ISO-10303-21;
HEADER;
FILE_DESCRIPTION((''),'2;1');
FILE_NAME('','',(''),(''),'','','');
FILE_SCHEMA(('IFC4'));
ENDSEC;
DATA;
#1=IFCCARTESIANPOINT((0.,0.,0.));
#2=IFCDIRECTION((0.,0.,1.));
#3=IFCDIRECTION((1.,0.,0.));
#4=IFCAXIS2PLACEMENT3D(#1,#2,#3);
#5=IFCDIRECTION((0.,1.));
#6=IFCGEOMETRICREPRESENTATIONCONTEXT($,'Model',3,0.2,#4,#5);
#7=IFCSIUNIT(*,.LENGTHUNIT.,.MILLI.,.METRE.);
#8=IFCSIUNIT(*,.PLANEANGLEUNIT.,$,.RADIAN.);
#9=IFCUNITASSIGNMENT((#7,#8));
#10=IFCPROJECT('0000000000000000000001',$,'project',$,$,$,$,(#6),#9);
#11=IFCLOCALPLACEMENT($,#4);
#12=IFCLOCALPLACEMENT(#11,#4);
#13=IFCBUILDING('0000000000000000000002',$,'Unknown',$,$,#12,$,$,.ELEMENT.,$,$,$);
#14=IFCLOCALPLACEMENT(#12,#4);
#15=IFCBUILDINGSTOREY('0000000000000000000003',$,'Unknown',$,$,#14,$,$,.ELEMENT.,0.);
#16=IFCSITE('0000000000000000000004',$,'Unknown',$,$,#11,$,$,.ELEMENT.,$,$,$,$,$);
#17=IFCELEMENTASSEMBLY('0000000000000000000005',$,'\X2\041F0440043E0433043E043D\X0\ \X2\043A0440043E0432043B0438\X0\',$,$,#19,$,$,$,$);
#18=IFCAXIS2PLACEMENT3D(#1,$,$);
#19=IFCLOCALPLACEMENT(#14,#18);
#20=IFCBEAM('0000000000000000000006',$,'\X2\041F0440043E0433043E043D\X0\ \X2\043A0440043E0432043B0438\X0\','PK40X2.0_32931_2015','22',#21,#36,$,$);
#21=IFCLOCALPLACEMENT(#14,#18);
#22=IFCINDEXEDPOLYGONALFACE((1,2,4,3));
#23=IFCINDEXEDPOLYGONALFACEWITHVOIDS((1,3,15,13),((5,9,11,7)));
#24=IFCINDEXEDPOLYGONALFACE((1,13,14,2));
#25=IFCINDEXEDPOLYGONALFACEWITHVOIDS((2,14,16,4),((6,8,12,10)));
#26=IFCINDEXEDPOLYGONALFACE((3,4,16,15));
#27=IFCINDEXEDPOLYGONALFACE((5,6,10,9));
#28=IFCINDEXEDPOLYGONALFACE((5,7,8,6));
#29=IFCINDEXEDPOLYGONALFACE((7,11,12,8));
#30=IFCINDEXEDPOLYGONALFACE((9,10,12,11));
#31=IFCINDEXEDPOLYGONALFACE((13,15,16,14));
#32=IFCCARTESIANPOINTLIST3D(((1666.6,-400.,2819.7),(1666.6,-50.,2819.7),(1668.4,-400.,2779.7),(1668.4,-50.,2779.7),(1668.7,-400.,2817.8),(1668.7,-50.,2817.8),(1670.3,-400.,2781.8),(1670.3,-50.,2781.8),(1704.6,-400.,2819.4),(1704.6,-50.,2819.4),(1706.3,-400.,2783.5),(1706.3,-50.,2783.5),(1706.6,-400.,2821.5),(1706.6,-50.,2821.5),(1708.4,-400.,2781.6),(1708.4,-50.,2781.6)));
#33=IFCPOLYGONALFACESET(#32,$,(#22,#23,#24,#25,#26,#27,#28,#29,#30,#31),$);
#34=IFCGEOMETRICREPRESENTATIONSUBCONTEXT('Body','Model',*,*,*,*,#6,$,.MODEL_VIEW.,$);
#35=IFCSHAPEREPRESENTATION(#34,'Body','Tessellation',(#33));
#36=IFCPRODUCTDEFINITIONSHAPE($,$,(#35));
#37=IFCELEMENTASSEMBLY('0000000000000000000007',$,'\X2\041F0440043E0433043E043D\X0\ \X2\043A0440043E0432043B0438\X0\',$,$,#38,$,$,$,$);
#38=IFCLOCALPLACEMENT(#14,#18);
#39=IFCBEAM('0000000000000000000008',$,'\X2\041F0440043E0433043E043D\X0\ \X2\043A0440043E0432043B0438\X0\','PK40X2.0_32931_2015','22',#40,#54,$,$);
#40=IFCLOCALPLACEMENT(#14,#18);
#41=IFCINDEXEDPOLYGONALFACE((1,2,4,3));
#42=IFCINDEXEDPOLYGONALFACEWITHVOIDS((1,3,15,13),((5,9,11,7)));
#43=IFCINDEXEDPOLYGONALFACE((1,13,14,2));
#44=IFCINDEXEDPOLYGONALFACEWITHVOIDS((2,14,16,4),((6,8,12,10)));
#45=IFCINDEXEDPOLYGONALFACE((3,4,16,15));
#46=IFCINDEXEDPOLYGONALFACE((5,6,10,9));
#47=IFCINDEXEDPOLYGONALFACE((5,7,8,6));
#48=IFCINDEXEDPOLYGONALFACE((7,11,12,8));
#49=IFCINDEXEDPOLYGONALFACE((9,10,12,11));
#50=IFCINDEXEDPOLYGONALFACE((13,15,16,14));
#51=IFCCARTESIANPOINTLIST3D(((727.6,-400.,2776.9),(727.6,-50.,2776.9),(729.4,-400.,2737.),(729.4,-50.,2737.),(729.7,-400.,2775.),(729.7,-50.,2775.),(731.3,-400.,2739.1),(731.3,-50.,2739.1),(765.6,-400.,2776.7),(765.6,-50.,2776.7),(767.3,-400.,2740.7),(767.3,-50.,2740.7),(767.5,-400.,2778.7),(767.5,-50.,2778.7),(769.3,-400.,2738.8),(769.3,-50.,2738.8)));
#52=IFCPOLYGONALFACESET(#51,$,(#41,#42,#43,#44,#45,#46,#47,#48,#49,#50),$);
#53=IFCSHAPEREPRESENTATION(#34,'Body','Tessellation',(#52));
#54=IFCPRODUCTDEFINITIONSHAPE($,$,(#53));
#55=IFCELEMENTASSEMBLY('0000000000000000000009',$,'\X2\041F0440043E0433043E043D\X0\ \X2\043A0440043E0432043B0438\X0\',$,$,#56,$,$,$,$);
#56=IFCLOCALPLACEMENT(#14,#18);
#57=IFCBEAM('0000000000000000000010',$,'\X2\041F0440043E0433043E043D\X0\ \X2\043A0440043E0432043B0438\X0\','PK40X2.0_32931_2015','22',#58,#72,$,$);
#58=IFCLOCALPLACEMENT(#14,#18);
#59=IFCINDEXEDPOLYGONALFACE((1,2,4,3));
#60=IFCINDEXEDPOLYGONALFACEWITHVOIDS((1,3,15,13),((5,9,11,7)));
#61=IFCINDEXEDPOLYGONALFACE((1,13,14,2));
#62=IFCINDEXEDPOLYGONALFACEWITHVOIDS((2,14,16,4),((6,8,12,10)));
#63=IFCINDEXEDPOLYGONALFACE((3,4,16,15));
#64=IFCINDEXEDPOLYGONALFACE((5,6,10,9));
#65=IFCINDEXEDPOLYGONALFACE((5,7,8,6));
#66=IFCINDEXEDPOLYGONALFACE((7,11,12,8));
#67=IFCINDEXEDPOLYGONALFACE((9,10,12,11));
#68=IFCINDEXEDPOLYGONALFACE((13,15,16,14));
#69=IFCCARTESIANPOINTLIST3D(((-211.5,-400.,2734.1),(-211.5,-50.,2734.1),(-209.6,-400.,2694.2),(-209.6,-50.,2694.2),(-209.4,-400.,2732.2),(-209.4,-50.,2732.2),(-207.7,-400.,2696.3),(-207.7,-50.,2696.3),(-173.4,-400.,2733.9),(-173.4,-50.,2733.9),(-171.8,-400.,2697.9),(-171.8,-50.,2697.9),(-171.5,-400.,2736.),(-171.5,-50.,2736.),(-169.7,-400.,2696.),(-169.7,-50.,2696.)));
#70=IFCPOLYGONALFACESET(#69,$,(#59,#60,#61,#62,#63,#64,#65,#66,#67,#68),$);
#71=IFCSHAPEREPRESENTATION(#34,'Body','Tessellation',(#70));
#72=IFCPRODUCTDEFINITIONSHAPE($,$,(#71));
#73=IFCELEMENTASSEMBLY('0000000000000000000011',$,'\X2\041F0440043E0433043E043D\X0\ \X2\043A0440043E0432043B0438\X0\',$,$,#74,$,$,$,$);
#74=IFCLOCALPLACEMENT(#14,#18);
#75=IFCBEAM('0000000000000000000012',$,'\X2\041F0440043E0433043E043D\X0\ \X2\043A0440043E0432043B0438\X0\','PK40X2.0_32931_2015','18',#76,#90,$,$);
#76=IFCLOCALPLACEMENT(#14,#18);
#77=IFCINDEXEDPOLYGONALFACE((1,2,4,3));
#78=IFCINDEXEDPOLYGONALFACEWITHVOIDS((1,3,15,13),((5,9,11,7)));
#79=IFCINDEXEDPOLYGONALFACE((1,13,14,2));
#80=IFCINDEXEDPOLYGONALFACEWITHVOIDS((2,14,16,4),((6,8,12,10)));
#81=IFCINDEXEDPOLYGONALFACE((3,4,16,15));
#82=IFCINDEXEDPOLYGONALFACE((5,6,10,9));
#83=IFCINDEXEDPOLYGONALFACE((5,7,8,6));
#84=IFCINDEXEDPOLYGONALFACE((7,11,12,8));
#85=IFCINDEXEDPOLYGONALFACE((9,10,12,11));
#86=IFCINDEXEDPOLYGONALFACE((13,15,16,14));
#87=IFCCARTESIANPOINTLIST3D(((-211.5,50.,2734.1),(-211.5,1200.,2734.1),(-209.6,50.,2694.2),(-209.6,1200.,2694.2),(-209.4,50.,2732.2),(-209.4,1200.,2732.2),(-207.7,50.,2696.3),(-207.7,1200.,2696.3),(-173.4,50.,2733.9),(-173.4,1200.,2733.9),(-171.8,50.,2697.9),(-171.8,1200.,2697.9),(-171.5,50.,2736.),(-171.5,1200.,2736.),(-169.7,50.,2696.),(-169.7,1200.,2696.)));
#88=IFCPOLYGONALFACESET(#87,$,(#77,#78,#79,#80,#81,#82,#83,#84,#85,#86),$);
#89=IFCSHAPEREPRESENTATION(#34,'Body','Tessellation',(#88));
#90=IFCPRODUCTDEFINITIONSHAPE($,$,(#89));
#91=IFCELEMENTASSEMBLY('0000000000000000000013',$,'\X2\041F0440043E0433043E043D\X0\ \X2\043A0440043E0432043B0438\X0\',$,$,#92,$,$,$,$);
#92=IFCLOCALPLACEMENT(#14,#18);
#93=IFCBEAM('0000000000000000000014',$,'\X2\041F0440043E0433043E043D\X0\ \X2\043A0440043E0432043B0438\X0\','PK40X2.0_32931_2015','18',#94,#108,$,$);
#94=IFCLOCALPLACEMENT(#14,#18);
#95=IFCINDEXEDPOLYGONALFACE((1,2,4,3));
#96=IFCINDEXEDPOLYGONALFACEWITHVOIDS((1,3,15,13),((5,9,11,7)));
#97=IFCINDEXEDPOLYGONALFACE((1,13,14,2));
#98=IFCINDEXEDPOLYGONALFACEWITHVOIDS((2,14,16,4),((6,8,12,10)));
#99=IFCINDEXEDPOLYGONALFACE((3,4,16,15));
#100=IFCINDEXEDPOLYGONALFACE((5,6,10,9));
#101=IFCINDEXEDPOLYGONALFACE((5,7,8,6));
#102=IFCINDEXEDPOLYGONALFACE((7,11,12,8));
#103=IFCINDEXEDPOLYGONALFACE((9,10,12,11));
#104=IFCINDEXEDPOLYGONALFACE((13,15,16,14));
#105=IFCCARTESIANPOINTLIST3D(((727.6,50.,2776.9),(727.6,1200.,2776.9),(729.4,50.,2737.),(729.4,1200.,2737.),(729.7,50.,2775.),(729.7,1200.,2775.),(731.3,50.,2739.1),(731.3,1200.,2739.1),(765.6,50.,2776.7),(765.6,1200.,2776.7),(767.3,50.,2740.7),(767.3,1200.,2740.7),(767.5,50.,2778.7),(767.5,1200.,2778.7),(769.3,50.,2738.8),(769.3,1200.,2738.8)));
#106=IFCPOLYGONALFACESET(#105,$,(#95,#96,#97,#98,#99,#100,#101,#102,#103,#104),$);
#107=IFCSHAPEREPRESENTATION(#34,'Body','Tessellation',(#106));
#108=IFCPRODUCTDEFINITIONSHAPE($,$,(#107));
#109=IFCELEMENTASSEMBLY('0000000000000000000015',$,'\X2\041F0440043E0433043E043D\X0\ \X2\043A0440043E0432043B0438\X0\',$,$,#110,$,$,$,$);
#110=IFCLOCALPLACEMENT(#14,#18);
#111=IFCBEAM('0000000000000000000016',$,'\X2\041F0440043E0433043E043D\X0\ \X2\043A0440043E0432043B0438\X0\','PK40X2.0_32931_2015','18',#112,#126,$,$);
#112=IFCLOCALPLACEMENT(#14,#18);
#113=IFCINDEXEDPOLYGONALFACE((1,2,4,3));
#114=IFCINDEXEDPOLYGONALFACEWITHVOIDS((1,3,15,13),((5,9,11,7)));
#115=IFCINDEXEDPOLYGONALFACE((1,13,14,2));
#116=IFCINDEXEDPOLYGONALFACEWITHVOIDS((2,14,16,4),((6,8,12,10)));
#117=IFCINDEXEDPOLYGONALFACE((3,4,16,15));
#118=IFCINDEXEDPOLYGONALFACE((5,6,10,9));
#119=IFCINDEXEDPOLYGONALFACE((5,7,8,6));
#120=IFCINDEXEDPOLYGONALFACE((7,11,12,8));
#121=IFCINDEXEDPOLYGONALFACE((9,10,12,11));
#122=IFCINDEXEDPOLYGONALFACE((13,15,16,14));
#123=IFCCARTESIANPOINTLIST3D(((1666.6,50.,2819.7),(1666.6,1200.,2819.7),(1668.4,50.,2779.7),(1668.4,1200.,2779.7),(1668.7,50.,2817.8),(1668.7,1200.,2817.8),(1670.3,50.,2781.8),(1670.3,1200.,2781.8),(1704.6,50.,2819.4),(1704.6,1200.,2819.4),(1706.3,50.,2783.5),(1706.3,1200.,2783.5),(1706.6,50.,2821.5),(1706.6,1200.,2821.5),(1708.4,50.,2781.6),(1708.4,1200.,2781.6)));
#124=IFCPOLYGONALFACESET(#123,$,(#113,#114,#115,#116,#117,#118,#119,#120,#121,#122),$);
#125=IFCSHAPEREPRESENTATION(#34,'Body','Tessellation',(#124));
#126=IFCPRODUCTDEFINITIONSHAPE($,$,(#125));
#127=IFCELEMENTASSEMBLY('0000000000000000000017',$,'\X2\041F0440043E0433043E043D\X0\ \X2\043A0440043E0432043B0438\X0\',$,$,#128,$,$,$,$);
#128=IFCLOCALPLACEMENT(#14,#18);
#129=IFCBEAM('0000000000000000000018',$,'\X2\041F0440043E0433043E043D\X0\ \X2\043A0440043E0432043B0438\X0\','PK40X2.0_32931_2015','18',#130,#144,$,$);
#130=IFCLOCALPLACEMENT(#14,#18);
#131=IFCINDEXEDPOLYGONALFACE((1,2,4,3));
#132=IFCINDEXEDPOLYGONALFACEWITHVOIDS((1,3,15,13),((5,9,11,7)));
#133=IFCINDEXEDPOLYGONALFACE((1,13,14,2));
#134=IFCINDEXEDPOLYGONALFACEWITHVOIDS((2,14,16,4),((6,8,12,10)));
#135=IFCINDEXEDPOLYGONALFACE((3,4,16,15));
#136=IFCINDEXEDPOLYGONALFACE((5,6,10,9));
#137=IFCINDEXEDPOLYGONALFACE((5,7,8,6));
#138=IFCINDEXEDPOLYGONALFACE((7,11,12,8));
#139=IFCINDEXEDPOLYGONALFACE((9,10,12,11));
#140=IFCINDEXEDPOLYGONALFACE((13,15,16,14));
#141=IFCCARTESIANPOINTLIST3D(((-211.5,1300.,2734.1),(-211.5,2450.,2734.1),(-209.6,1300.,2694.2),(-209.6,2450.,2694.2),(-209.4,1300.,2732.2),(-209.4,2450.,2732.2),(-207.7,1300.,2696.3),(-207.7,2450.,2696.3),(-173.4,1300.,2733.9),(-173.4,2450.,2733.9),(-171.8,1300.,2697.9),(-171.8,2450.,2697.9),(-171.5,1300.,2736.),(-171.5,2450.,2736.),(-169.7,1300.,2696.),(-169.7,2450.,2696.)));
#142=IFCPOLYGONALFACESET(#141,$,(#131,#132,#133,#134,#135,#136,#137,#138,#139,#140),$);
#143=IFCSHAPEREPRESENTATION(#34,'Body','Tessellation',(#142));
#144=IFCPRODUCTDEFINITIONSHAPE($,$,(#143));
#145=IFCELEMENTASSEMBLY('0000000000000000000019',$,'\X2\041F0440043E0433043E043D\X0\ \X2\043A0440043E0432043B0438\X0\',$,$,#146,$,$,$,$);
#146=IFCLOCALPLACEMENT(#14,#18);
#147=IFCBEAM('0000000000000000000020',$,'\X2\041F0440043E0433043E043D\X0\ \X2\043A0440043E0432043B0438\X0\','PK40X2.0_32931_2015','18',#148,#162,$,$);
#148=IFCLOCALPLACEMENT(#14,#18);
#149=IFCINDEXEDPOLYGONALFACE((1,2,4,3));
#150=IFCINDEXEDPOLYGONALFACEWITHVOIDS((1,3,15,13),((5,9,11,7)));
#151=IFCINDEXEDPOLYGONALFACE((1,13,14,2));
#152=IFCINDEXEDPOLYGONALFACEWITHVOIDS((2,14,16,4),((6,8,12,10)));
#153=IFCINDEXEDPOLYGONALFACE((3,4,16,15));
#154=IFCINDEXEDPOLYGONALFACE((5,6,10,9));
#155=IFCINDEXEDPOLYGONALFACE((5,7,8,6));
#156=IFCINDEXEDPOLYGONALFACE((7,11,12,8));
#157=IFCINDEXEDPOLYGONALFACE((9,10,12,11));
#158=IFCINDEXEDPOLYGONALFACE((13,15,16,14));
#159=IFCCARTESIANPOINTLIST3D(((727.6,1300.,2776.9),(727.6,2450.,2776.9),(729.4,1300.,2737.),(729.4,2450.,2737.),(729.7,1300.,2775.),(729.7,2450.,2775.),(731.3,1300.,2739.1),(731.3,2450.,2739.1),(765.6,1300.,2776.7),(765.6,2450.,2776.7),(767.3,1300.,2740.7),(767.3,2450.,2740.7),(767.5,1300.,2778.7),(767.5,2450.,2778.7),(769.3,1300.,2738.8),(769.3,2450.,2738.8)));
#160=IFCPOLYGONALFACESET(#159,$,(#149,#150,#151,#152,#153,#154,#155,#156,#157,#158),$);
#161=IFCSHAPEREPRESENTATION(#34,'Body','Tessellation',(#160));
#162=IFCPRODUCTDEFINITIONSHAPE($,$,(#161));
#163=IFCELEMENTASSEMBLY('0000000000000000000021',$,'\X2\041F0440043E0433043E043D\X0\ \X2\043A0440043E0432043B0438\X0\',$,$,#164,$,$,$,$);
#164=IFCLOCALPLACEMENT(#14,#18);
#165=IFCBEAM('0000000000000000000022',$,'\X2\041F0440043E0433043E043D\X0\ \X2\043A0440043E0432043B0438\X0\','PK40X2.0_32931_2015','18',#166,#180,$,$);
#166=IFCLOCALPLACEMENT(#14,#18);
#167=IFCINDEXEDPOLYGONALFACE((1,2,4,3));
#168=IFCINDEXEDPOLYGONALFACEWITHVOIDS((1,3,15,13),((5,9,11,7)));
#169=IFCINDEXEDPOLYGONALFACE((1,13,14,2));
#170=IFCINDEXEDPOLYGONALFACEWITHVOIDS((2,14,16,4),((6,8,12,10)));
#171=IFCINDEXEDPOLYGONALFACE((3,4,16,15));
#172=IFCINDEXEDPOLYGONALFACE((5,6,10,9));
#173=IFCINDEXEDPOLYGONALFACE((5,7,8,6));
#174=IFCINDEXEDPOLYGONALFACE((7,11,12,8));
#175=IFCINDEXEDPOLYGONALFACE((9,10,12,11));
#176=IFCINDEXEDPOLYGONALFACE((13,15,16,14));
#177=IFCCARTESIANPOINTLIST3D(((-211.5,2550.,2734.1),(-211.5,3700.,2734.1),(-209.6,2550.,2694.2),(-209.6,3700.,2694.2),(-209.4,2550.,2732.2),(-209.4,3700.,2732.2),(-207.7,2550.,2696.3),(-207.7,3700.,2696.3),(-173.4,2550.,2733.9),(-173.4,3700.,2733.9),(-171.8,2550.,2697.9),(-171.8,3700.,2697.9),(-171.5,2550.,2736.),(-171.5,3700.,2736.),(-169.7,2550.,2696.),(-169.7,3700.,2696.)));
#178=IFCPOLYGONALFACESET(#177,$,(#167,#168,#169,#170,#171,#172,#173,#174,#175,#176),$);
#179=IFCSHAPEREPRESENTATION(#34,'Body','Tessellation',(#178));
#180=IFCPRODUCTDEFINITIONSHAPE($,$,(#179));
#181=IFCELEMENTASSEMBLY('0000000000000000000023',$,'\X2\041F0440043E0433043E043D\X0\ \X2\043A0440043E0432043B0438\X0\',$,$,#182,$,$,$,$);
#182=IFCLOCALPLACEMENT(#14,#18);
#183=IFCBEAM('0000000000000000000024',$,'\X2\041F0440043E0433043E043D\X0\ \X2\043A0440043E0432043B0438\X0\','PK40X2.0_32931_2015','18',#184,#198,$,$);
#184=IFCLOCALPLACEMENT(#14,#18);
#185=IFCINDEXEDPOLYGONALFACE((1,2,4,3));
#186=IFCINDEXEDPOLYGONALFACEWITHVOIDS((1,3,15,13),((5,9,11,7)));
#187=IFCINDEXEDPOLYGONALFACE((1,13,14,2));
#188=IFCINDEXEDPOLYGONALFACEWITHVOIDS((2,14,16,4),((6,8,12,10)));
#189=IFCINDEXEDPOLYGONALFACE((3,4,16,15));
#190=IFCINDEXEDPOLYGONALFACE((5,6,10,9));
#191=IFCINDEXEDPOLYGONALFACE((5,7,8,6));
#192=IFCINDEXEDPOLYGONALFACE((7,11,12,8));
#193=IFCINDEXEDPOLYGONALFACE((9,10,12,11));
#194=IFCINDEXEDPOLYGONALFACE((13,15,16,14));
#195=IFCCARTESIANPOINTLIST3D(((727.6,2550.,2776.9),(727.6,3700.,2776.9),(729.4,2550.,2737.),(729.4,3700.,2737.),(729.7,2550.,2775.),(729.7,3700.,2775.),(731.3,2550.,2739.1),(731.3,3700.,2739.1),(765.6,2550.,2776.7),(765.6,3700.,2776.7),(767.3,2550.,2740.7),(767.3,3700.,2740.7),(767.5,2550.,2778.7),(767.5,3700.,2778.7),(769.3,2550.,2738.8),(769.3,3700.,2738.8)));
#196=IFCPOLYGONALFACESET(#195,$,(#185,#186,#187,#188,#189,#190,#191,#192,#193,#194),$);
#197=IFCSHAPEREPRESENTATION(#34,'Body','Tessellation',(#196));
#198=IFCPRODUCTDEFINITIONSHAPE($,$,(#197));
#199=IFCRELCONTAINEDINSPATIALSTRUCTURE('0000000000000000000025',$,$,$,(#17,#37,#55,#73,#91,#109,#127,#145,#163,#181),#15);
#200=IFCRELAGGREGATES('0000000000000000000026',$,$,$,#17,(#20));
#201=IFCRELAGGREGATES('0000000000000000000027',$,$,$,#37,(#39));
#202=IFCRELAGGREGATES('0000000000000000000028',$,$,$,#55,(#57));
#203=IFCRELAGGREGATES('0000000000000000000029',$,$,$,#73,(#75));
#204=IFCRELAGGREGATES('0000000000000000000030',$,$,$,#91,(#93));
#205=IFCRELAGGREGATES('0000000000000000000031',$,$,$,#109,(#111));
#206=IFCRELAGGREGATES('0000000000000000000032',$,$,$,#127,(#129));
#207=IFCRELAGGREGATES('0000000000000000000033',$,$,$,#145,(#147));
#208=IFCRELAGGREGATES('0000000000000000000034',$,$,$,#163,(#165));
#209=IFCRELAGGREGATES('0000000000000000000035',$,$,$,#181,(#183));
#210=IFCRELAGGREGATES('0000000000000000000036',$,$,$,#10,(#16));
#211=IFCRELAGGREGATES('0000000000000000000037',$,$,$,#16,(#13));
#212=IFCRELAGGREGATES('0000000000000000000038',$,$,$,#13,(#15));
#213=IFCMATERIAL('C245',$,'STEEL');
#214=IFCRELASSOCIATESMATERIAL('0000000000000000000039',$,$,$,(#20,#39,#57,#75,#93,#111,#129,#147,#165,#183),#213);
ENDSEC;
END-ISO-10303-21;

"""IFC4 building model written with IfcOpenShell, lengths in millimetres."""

from ifc_helpers import new_model, si_unit, direction, frame, origin_with_axes, place, context, subcontext, project, spatial, line, indexed_curve, outline, extrude, material, element, aggregate, save


model = new_model("IFC4")

# Units and contexts
model_context = context("Model", 3, precision=0.2, world=origin_with_axes(), true_north=direction((0.0, 1.0)))
body_context = subcontext(model_context, "Body", "Model", "MODEL_VIEW")
ifc_project = project(units=[si_unit("LENGTHUNIT", "METRE", prefix="MILLI"), si_unit("PLANEANGLEUNIT", "RADIAN")], contexts=[model_context])

# Site, building, storey
site_placement = place(None, origin_with_axes())
site = spatial("IfcSite", under=ifc_project, at=site_placement, Name="Unknown", CompositionType="ELEMENT")
building_placement = place(site_placement, origin_with_axes())
building = spatial("IfcBuilding", under=site, at=building_placement, Name="Unknown", CompositionType="ELEMENT")
storey_placement = place(building_placement, origin_with_axes())
storey = spatial("IfcBuildingStorey", under=building, at=storey_placement, Name="Unknown", CompositionType="ELEMENT", Elevation=0.0)

# Shared definitions
ifc_material = material(Name="C245", Category="STEEL")

# Element assemblies, beams
assembly_1_placement = place(storey_placement, frame((1687.5, -50.0, 2800.6), z_axis=(-0.998964, 0.0, -0.045508), x_axis=(0.0, -1.0, 0.0)))
assembly_1 = element("IfcElementAssembly", 1, at=assembly_1_placement, inside=storey, Name="Прогон кровли")
beam_1_placement = place(assembly_1_placement, origin_with_axes())
beam_1 = element("IfcBeam", 2, at=beam_1_placement, material=ifc_material, Name="Прогон кровли", Description="PK40X2.0_32931_2015", ObjectType="22", context=body_context, shape_type="SolidModel", body=[
    extrude(outline(indexed_curve([(-20.0, -20.0), (20.0, -20.0), (20.0, 20.0), (-20.0, 20.0)], segments=[line(1, 2, 3, 4, 1)]), holes=[indexed_curve([(-18.0, -18.0), (-18.0, 18.0), (18.0, 18.0), (18.0, -18.0)], segments=[line(1, 2, 3, 4, 1)])]), frame((0.0, 0.0, 0.0), z_axis=(-1.0, 0.0, 0.0), x_axis=(0.0, 0.0, 1.0)), (0.0, 0.0, -1.0), 350.0),
])
aggregate(assembly_1, [beam_1])
assembly_2_placement = place(storey_placement, frame((748.5, -50.0, 2757.9), z_axis=(-0.998964, 0.0, -0.045508), x_axis=(0.0, -1.0, 0.0)))
assembly_2 = element("IfcElementAssembly", 3, at=assembly_2_placement, inside=storey, Name="Прогон кровли")
beam_2_placement = place(assembly_2_placement, origin_with_axes())
beam_2 = element("IfcBeam", 4, at=beam_2_placement, material=ifc_material, Name="Прогон кровли", Description="PK40X2.0_32931_2015", ObjectType="22", context=body_context, shape_type="SolidModel", body=[
    extrude(outline(indexed_curve([(-20.0, -20.0), (20.0, -20.0), (20.0, 20.0), (-20.0, 20.0)], segments=[line(1, 2, 3, 4, 1)]), holes=[indexed_curve([(-18.0, -18.0), (-18.0, 18.0), (18.0, 18.0), (18.0, -18.0)], segments=[line(1, 2, 3, 4, 1)])]), frame((0.0, 0.0, 0.0), z_axis=(-1.0, 0.0, 0.0), x_axis=(0.0, 0.0, 1.0)), (0.0, 0.0, -1.0), 350.0),
])
aggregate(assembly_2, [beam_2])
assembly_3_placement = place(storey_placement, frame((-190.6, -50.0, 2715.1), z_axis=(-0.998964, 0.0, -0.045508), x_axis=(0.0, -1.0, 0.0)))
assembly_3 = element("IfcElementAssembly", 5, at=assembly_3_placement, inside=storey, Name="Прогон кровли")
beam_3_placement = place(assembly_3_placement, origin_with_axes())
beam_3 = element("IfcBeam", 6, at=beam_3_placement, material=ifc_material, Name="Прогон кровли", Description="PK40X2.0_32931_2015", ObjectType="22", context=body_context, shape_type="SolidModel", body=[
    extrude(outline(indexed_curve([(-20.0, -20.0), (20.0, -20.0), (20.0, 20.0), (-20.0, 20.0)], segments=[line(1, 2, 3, 4, 1)]), holes=[indexed_curve([(-18.0, -18.0), (-18.0, 18.0), (18.0, 18.0), (18.0, -18.0)], segments=[line(1, 2, 3, 4, 1)])]), frame((0.0, 0.0, 0.0), z_axis=(-1.0, 0.0, 0.0), x_axis=(0.0, 0.0, 1.0)), (0.0, 0.0, -1.0), 350.0),
])
aggregate(assembly_3, [beam_3])
assembly_4_placement = place(storey_placement, frame((-190.6, 1200.0, 2715.1), z_axis=(-0.998964, 0.0, -0.045508), x_axis=(0.0, -1.0, 0.0)))
assembly_4 = element("IfcElementAssembly", 7, at=assembly_4_placement, inside=storey, Name="Прогон кровли")
beam_4_placement = place(assembly_4_placement, origin_with_axes())
beam_4 = element("IfcBeam", 8, at=beam_4_placement, material=ifc_material, Name="Прогон кровли", Description="PK40X2.0_32931_2015", ObjectType="18", context=body_context, shape_type="SolidModel", body=[
    extrude(outline(indexed_curve([(-20.0, -20.0), (20.0, -20.0), (20.0, 20.0), (-20.0, 20.0)], segments=[line(1, 2, 3, 4, 1)]), holes=[indexed_curve([(-18.0, -18.0), (-18.0, 18.0), (18.0, 18.0), (18.0, -18.0)], segments=[line(1, 2, 3, 4, 1)])]), frame((0.0, 0.0, 0.0), z_axis=(-1.0, 0.0, 0.0), x_axis=(0.0, 0.0, 1.0)), (0.0, 0.0, -1.0), 1150.0),
])
aggregate(assembly_4, [beam_4])
assembly_5_placement = place(storey_placement, frame((748.5, 1200.0, 2757.9), z_axis=(-0.998964, 0.0, -0.045508), x_axis=(0.0, -1.0, 0.0)))
assembly_5 = element("IfcElementAssembly", 9, at=assembly_5_placement, inside=storey, Name="Прогон кровли")
beam_5_placement = place(assembly_5_placement, origin_with_axes())
beam_5 = element("IfcBeam", 10, at=beam_5_placement, material=ifc_material, Name="Прогон кровли", Description="PK40X2.0_32931_2015", ObjectType="18", context=body_context, shape_type="SolidModel", body=[
    extrude(outline(indexed_curve([(-20.0, -20.0), (20.0, -20.0), (20.0, 20.0), (-20.0, 20.0)], segments=[line(1, 2, 3, 4, 1)]), holes=[indexed_curve([(-18.0, -18.0), (-18.0, 18.0), (18.0, 18.0), (18.0, -18.0)], segments=[line(1, 2, 3, 4, 1)])]), frame((0.0, 0.0, 0.0), z_axis=(-1.0, 0.0, 0.0), x_axis=(0.0, 0.0, 1.0)), (0.0, 0.0, -1.0), 1150.0),
])
aggregate(assembly_5, [beam_5])
assembly_6_placement = place(storey_placement, frame((1687.5, 1200.0, 2800.6), z_axis=(-0.998964, 0.0, -0.045508), x_axis=(0.0, -1.0, 0.0)))
assembly_6 = element("IfcElementAssembly", 11, at=assembly_6_placement, inside=storey, Name="Прогон кровли")
beam_6_placement = place(assembly_6_placement, origin_with_axes())
beam_6 = element("IfcBeam", 12, at=beam_6_placement, material=ifc_material, Name="Прогон кровли", Description="PK40X2.0_32931_2015", ObjectType="18", context=body_context, shape_type="SolidModel", body=[
    extrude(outline(indexed_curve([(-20.0, -20.0), (20.0, -20.0), (20.0, 20.0), (-20.0, 20.0)], segments=[line(1, 2, 3, 4, 1)]), holes=[indexed_curve([(-18.0, -18.0), (-18.0, 18.0), (18.0, 18.0), (18.0, -18.0)], segments=[line(1, 2, 3, 4, 1)])]), frame((0.0, 0.0, 0.0), z_axis=(-1.0, 0.0, 0.0), x_axis=(0.0, 0.0, 1.0)), (0.0, 0.0, -1.0), 1150.0),
])
aggregate(assembly_6, [beam_6])
assembly_7_placement = place(storey_placement, frame((-190.6, 2450.0, 2715.1), z_axis=(-0.998964, 0.0, -0.045508), x_axis=(0.0, -1.0, 0.0)))
assembly_7 = element("IfcElementAssembly", 13, at=assembly_7_placement, inside=storey, Name="Прогон кровли")
beam_7_placement = place(assembly_7_placement, origin_with_axes())
beam_7 = element("IfcBeam", 14, at=beam_7_placement, material=ifc_material, Name="Прогон кровли", Description="PK40X2.0_32931_2015", ObjectType="18", context=body_context, shape_type="SolidModel", body=[
    extrude(outline(indexed_curve([(-20.0, -20.0), (20.0, -20.0), (20.0, 20.0), (-20.0, 20.0)], segments=[line(1, 2, 3, 4, 1)]), holes=[indexed_curve([(-18.0, -18.0), (-18.0, 18.0), (18.0, 18.0), (18.0, -18.0)], segments=[line(1, 2, 3, 4, 1)])]), frame((0.0, 0.0, 0.0), z_axis=(-1.0, 0.0, 0.0), x_axis=(0.0, 0.0, 1.0)), (0.0, 0.0, -1.0), 1150.0),
])
aggregate(assembly_7, [beam_7])
assembly_8_placement = place(storey_placement, frame((748.5, 2450.0, 2757.9), z_axis=(-0.998964, 0.0, -0.045508), x_axis=(0.0, -1.0, 0.0)))
assembly_8 = element("IfcElementAssembly", 15, at=assembly_8_placement, inside=storey, Name="Прогон кровли")
beam_8_placement = place(assembly_8_placement, origin_with_axes())
beam_8 = element("IfcBeam", 16, at=beam_8_placement, material=ifc_material, Name="Прогон кровли", Description="PK40X2.0_32931_2015", ObjectType="18", context=body_context, shape_type="SolidModel", body=[
    extrude(outline(indexed_curve([(-20.0, -20.0), (20.0, -20.0), (20.0, 20.0), (-20.0, 20.0)], segments=[line(1, 2, 3, 4, 1)]), holes=[indexed_curve([(-18.0, -18.0), (-18.0, 18.0), (18.0, 18.0), (18.0, -18.0)], segments=[line(1, 2, 3, 4, 1)])]), frame((0.0, 0.0, 0.0), z_axis=(-1.0, 0.0, 0.0), x_axis=(0.0, 0.0, 1.0)), (0.0, 0.0, -1.0), 1150.0),
])
aggregate(assembly_8, [beam_8])
assembly_9_placement = place(storey_placement, frame((-190.6, 3700.0, 2715.1), z_axis=(-0.998964, 0.0, -0.045508), x_axis=(0.0, -1.0, 0.0)))
assembly_9 = element("IfcElementAssembly", 17, at=assembly_9_placement, inside=storey, Name="Прогон кровли")
beam_9_placement = place(assembly_9_placement, origin_with_axes())
beam_9 = element("IfcBeam", 18, at=beam_9_placement, material=ifc_material, Name="Прогон кровли", Description="PK40X2.0_32931_2015", ObjectType="18", context=body_context, shape_type="SolidModel", body=[
    extrude(outline(indexed_curve([(-20.0, -20.0), (20.0, -20.0), (20.0, 20.0), (-20.0, 20.0)], segments=[line(1, 2, 3, 4, 1)]), holes=[indexed_curve([(-18.0, -18.0), (-18.0, 18.0), (18.0, 18.0), (18.0, -18.0)], segments=[line(1, 2, 3, 4, 1)])]), frame((0.0, 0.0, 0.0), z_axis=(-1.0, 0.0, 0.0), x_axis=(0.0, 0.0, 1.0)), (0.0, 0.0, -1.0), 1150.0),
])
aggregate(assembly_9, [beam_9])
assembly_10_placement = place(storey_placement, frame((748.5, 3700.0, 2757.9), z_axis=(-0.998964, 0.0, -0.045508), x_axis=(0.0, -1.0, 0.0)))
assembly_10 = element("IfcElementAssembly", 19, at=assembly_10_placement, inside=storey, Name="Прогон кровли")
beam_10_placement = place(assembly_10_placement, origin_with_axes())
beam_10 = element("IfcBeam", 20, at=beam_10_placement, material=ifc_material, Name="Прогон кровли", Description="PK40X2.0_32931_2015", ObjectType="18", context=body_context, shape_type="SolidModel", body=[
    extrude(outline(indexed_curve([(-20.0, -20.0), (20.0, -20.0), (20.0, 20.0), (-20.0, 20.0)], segments=[line(1, 2, 3, 4, 1)]), holes=[indexed_curve([(-18.0, -18.0), (-18.0, 18.0), (18.0, 18.0), (18.0, -18.0)], segments=[line(1, 2, 3, 4, 1)])]), frame((0.0, 0.0, 0.0), z_axis=(-1.0, 0.0, 0.0), x_axis=(0.0, 0.0, 1.0)), (0.0, 0.0, -1.0), 1150.0),
])
aggregate(assembly_10, [beam_10])

save(model, "model.ifc")
